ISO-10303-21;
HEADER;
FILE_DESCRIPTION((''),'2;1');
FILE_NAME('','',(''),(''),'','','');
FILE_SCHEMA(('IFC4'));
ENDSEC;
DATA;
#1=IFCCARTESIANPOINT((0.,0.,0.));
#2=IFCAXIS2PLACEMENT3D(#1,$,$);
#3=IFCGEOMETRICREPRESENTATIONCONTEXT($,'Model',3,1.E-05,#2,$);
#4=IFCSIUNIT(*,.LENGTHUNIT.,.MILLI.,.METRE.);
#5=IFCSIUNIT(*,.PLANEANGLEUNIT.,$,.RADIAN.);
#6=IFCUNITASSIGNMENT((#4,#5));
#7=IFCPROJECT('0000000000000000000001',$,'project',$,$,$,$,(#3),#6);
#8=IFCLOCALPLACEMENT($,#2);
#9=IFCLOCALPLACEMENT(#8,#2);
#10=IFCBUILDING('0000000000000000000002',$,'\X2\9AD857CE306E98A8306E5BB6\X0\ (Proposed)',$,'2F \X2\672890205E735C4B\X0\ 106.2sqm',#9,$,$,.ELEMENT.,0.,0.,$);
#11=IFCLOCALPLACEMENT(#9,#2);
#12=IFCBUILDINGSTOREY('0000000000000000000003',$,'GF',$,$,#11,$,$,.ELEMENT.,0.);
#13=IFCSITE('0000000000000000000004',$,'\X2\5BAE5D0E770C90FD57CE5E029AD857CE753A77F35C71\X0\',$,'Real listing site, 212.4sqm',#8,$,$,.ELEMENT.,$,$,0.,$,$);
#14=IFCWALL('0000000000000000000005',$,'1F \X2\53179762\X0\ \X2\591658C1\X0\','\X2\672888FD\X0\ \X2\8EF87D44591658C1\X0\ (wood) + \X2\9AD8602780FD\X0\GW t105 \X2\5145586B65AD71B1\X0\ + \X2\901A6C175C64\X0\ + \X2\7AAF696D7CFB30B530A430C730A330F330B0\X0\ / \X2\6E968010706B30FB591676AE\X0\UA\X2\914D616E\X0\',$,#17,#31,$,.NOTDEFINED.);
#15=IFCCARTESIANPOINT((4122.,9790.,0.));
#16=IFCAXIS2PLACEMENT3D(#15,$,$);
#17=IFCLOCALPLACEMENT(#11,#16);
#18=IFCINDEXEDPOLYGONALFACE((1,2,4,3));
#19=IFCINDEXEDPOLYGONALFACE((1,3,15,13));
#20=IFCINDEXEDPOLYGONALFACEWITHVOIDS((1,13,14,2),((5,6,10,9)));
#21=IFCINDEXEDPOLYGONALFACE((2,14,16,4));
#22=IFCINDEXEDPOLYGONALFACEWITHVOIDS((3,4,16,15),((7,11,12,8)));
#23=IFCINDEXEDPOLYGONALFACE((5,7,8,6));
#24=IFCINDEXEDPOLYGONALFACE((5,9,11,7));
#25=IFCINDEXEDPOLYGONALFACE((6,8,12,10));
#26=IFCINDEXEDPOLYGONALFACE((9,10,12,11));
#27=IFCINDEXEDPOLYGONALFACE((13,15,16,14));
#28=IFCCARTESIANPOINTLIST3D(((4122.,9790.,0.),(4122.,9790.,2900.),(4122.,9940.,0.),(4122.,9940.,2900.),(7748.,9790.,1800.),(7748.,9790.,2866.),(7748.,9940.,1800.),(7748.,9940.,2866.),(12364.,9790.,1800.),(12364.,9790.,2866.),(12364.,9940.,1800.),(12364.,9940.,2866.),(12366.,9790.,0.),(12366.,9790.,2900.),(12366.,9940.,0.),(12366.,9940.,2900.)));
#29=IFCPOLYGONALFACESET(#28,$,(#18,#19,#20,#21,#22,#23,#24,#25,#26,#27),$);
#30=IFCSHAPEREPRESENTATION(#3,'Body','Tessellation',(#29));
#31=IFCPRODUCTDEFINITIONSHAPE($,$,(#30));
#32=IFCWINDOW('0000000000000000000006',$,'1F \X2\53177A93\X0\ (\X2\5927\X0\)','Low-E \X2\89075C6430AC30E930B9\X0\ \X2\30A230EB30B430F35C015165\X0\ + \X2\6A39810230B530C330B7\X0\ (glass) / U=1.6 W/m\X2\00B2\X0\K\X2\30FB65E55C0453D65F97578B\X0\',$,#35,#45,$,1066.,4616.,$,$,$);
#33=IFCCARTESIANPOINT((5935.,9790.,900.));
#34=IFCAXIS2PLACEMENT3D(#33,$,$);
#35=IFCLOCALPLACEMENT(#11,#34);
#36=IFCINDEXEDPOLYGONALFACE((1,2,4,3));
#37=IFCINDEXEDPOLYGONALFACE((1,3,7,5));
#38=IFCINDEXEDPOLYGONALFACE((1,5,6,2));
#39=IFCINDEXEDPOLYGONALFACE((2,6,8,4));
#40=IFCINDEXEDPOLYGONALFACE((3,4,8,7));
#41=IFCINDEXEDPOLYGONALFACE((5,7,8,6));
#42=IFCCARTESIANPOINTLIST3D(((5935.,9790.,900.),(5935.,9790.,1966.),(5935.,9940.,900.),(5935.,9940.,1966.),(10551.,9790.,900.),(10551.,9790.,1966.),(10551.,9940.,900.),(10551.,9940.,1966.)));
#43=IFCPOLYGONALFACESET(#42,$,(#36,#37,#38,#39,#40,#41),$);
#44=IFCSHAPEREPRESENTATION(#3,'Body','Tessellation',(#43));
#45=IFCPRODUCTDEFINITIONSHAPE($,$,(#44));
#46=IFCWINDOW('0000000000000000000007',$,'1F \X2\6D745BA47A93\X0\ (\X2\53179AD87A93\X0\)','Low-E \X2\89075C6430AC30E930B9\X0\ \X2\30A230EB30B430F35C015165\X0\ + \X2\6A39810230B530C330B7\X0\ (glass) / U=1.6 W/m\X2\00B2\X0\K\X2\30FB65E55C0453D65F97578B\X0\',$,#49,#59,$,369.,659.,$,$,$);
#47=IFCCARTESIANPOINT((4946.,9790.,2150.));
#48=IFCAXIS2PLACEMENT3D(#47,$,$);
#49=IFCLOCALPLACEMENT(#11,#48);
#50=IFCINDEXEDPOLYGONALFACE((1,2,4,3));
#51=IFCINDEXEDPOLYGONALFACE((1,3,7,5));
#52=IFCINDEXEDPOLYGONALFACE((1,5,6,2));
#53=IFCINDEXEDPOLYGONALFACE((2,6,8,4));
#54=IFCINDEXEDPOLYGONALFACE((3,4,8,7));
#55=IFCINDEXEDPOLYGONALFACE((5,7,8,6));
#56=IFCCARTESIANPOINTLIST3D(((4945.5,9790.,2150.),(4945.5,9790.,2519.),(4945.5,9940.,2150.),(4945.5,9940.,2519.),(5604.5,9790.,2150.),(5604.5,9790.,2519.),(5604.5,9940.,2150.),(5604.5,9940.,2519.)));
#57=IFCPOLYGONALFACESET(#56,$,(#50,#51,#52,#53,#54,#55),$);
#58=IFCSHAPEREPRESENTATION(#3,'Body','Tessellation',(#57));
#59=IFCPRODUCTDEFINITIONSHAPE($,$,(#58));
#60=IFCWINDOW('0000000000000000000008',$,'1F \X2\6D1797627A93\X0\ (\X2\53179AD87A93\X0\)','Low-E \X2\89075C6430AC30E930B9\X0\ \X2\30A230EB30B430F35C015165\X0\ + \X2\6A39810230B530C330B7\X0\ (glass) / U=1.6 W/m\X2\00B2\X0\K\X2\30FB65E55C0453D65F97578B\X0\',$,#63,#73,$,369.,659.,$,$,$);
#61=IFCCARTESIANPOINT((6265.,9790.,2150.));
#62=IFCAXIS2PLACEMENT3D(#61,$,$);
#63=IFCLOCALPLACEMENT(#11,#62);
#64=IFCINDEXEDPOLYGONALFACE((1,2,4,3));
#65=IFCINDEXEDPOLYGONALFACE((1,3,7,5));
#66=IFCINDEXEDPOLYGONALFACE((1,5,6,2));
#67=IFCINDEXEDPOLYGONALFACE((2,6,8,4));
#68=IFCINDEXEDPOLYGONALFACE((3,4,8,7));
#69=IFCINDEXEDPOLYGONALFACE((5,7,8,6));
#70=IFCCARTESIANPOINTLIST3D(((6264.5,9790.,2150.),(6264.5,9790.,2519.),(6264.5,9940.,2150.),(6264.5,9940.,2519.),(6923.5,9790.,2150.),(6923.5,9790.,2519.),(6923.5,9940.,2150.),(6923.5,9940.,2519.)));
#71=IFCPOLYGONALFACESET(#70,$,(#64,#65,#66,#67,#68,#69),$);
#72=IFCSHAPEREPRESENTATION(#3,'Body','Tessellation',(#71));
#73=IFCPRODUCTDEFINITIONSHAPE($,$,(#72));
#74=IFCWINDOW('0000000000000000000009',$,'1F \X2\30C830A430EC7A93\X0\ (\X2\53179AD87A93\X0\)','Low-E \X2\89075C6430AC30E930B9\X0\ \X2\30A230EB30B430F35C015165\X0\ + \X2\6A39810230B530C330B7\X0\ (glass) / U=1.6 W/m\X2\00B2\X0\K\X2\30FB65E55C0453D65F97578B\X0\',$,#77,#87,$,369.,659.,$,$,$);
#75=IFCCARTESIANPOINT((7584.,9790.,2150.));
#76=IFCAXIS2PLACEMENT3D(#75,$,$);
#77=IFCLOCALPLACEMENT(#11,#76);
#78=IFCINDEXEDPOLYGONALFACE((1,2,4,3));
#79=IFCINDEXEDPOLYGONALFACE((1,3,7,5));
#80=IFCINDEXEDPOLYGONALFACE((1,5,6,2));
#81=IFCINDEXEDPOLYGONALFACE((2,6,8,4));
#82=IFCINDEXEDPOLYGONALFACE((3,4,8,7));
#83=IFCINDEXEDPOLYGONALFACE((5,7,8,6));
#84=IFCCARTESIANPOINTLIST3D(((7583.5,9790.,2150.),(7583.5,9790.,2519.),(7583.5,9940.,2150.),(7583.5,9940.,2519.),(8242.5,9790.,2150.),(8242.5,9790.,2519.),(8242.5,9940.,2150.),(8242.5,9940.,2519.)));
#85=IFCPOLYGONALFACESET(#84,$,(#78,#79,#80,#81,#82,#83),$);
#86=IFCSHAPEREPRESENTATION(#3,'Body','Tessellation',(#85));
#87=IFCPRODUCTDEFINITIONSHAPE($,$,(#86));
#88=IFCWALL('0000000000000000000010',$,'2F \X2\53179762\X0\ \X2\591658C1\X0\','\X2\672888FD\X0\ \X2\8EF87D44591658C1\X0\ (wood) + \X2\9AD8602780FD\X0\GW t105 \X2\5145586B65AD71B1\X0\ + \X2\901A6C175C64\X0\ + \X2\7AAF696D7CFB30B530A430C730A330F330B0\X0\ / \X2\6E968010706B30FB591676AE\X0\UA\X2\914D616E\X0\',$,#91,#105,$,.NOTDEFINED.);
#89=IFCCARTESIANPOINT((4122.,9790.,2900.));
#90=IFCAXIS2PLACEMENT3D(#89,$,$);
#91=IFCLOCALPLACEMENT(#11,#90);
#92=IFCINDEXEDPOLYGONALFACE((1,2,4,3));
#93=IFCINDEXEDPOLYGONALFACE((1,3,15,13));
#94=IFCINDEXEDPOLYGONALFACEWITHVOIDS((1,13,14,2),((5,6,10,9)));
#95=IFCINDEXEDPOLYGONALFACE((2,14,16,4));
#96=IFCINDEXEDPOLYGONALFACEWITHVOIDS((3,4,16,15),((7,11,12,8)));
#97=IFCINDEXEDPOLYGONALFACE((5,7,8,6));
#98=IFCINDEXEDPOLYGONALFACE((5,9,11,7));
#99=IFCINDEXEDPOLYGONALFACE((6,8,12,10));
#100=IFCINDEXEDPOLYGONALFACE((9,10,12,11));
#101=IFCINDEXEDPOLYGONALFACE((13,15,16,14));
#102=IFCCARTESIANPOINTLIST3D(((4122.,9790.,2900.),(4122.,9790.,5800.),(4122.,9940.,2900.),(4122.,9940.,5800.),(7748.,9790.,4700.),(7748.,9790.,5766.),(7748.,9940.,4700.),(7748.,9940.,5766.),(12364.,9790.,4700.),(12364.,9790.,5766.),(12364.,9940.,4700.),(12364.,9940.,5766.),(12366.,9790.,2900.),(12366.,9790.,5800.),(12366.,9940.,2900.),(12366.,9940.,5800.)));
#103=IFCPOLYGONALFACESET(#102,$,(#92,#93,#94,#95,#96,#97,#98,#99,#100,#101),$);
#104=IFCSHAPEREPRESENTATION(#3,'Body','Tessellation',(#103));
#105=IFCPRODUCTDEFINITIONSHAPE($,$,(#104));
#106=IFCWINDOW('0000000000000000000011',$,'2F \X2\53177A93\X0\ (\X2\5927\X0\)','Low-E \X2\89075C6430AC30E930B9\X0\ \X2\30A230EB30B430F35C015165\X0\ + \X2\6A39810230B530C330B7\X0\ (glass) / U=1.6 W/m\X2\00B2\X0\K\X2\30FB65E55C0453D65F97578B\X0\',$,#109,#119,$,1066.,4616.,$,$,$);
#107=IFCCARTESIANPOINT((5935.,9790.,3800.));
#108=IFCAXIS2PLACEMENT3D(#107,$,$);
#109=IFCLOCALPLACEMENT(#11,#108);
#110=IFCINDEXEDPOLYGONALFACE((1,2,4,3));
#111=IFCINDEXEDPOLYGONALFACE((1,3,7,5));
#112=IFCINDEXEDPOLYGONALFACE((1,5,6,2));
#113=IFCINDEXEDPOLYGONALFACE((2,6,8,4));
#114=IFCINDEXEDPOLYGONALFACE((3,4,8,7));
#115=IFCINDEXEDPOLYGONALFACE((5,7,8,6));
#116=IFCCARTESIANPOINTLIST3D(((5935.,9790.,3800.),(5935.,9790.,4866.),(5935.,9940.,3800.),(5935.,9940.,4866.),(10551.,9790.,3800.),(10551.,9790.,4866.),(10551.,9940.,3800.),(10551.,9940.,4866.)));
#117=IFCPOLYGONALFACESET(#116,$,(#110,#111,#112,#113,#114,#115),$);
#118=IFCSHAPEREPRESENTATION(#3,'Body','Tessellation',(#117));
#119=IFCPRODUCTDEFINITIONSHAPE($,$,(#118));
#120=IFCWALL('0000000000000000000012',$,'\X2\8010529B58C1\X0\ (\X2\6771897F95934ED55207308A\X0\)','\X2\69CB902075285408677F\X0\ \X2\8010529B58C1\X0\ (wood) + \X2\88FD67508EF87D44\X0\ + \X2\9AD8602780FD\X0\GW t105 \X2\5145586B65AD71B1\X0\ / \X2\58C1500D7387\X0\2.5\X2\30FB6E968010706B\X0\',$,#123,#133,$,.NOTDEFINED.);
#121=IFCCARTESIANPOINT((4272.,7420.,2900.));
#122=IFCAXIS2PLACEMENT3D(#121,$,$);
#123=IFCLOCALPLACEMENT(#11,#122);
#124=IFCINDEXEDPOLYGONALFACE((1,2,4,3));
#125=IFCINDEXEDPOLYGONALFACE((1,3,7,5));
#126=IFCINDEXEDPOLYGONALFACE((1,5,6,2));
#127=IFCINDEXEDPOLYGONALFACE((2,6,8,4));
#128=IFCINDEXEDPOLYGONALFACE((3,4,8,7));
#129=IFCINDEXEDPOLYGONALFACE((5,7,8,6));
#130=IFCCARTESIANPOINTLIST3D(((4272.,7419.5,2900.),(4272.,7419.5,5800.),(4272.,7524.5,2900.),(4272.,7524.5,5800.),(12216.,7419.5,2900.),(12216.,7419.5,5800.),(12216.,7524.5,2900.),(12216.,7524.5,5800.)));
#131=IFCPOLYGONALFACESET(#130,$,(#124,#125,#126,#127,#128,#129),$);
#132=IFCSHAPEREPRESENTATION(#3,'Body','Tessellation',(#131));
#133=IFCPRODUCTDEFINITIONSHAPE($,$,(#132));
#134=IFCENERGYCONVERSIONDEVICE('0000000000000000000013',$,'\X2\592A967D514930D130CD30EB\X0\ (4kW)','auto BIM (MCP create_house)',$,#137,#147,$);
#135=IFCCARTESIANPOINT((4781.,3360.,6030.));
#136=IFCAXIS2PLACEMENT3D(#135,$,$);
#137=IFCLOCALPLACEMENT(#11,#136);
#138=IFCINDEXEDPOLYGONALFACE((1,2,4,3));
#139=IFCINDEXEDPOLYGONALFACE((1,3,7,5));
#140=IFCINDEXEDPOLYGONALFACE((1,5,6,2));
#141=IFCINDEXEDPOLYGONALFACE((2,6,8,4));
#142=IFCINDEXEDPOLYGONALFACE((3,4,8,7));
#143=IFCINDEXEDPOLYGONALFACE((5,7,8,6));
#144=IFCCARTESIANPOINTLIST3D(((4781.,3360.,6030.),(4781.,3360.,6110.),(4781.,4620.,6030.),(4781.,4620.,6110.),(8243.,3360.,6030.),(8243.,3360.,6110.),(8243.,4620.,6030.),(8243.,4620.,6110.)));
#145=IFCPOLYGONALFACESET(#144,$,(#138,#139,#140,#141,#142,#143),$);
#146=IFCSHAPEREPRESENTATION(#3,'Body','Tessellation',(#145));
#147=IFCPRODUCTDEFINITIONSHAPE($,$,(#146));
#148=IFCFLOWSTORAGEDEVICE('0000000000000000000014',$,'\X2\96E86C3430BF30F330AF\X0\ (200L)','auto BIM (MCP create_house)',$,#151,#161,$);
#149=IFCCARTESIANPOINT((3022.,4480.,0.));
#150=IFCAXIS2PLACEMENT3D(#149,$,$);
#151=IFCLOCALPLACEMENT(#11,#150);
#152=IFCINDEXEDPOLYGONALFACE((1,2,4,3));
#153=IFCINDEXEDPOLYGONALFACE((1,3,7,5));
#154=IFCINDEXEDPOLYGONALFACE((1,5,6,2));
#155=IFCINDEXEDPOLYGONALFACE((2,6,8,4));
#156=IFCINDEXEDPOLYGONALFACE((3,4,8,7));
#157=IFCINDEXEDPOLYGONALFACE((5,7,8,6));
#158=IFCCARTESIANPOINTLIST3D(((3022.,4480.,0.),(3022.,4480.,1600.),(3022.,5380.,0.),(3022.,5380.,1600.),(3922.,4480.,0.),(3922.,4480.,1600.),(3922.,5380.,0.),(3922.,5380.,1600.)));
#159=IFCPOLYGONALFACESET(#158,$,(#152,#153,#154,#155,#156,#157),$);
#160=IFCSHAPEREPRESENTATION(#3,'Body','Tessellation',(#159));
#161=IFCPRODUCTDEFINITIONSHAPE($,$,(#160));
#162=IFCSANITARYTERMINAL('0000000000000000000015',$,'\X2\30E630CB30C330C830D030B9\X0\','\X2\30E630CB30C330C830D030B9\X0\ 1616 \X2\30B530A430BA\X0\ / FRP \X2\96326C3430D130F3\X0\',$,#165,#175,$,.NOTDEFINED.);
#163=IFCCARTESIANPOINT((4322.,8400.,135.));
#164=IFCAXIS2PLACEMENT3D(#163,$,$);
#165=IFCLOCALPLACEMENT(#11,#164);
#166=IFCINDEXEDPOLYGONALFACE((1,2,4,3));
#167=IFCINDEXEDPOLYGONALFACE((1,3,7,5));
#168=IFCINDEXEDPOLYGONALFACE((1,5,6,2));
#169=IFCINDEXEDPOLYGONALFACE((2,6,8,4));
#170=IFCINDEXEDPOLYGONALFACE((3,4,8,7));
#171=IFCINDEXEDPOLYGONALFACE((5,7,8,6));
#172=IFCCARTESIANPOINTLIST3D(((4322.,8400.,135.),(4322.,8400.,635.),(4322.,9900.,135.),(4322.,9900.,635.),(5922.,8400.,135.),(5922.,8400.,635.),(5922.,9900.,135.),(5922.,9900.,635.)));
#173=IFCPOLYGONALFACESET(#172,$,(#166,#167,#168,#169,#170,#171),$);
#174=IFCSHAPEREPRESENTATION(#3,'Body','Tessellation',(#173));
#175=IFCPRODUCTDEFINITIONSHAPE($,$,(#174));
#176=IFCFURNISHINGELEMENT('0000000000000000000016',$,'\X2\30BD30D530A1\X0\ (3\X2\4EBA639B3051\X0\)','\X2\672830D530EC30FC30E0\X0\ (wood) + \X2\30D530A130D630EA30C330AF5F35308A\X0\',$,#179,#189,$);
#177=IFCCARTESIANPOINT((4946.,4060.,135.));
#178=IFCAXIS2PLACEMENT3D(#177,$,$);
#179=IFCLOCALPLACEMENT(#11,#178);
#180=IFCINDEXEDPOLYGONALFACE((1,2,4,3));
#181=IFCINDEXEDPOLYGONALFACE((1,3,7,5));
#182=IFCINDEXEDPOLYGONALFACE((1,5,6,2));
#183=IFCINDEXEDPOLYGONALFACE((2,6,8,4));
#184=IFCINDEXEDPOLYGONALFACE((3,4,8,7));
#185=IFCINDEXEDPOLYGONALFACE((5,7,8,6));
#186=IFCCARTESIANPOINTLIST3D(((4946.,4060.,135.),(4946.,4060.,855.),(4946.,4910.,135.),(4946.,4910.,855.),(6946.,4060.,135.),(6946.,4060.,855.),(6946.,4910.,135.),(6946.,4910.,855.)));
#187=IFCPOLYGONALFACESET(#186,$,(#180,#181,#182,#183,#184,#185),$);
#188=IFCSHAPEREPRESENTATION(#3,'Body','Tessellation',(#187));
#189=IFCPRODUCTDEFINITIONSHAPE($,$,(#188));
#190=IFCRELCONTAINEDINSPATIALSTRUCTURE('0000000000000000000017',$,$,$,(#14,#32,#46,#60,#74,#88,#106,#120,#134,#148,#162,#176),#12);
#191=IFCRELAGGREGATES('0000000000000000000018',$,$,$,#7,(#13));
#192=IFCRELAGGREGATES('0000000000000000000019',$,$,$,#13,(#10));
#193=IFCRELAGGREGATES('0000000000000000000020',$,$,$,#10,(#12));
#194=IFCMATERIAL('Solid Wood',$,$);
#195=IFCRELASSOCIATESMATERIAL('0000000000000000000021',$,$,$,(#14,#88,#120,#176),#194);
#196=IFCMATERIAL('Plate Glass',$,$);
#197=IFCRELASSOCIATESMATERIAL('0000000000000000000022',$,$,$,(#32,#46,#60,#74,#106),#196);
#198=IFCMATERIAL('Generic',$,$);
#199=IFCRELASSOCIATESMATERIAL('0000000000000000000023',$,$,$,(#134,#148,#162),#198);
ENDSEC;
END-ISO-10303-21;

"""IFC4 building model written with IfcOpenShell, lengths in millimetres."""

from ifc_helpers import new_model, si_unit, frame, frame_2d, origin, place, context, project, spatial, rectangle, extrude, material, element, fill, save


model = new_model("IFC4")

# Units and contexts
model_context = context("Model", 3, precision=1e-05, world=origin())
ifc_project = project(units=[si_unit("LENGTHUNIT", "METRE", prefix="MILLI"), si_unit("PLANEANGLEUNIT", "RADIAN")], contexts=[model_context])

# Site, building, storey
site_placement = place(None, origin())
site = spatial("IfcSite", under=ifc_project, at=site_placement, Name="宮崎県都城市高城町石山", ObjectType="Real listing site, 212.4sqm", CompositionType="ELEMENT", RefElevation=0.0)
building_placement = place(site_placement, origin())
building = spatial("IfcBuilding", under=site, at=building_placement, Name="高城の風の家 (Proposed)", ObjectType="2F 木造平屋 106.2sqm", CompositionType="ELEMENT", ElevationOfRefHeight=0.0, ElevationOfTerrain=0.0)
storey_placement = place(building_placement, origin())
storey = spatial("IfcBuildingStorey", under=building, at=storey_placement, Name="GF", CompositionType="ELEMENT", Elevation=0.0)

# Wall, openings, windows
ifc_material_1 = material(Name="Solid Wood")
wall_1_placement = place(storey_placement, frame((4122.0, 9790.0, 0.0)))
wall_1 = element("IfcWall", 1, at=wall_1_placement, inside=storey, material=ifc_material_1, Name="1F 北面 外壁", Description="木製 軸組外壁 (wood) + 高性能GW t105 充填断熱 + 通気層 + 窯業系サイディング / 準耐火・外皮UA配慮", PredefinedType="NOTDEFINED", context=model_context, shape_type="SweptSolid", body=[
    extrude(rectangle(XDim=8244.0, YDim=150.0, at=frame_2d((4122.0, 75.0))), frame((4122.0, 9790.0, 0.0)), (0.0, 0.0, 1.0), 2900.0),
])
opening_1_placement = place(storey_placement, frame((5935.0, 9790.0, 900.0)))
opening_1 = element("IfcOpeningElement", 2, at=opening_1_placement, cuts=wall_1, PredefinedType="NOTDEFINED", context=model_context, shape_type="SweptSolid", body=[
    extrude(rectangle(XDim=4616.0, YDim=150.0, at=frame_2d((2308.0, 75.0))), frame((5935.0, 9790.0, 900.0)), (0.0, 0.0, 1.0), 1066.0),
])
opening_2_placement = place(storey_placement, frame((4946.0, 9790.0, 2150.0)))
opening_2 = element("IfcOpeningElement", 3, at=opening_2_placement, cuts=wall_1, PredefinedType="NOTDEFINED", context=model_context, shape_type="SweptSolid", body=[
    extrude(rectangle(XDim=659.0, YDim=150.0, at=frame_2d((329.0, 75.0))), frame((4946.0, 9790.0, 2150.0)), (0.0, 0.0, 1.0), 369.0),
])
opening_3_placement = place(storey_placement, frame((6265.0, 9790.0, 2150.0)))
opening_3 = element("IfcOpeningElement", 4, at=opening_3_placement, cuts=wall_1, PredefinedType="NOTDEFINED", context=model_context, shape_type="SweptSolid", body=[
    extrude(rectangle(XDim=659.0, YDim=150.0, at=frame_2d((329.0, 75.0))), frame((6265.0, 9790.0, 2150.0)), (0.0, 0.0, 1.0), 369.0),
])
opening_4_placement = place(storey_placement, frame((7584.0, 9790.0, 2150.0)))
opening_4 = element("IfcOpeningElement", 5, at=opening_4_placement, cuts=wall_1, PredefinedType="NOTDEFINED", context=model_context, shape_type="SweptSolid", body=[
    extrude(rectangle(XDim=659.0, YDim=150.0, at=frame_2d((329.0, 75.0))), frame((7584.0, 9790.0, 2150.0)), (0.0, 0.0, 1.0), 369.0),
])
ifc_material_2 = material(Name="Plate Glass")
window_1_placement = place(storey_placement, frame((5935.0, 9790.0, 900.0)))
window_1 = element("IfcWindow", 6, at=window_1_placement, inside=storey, material=ifc_material_2, Name="1F 北窓 (大)", Description="Low-E 複層ガラス アルゴン封入 + 樹脂サッシ (glass) / U=1.6 W/m²K・日射取得型", OverallHeight=1066.0, OverallWidth=4616.0, context=model_context, shape_type="SweptSolid", body=[
    extrude(rectangle(XDim=4616.0, YDim=150.0, at=frame_2d((2308.0, 75.0))), frame((5935.0, 9790.0, 900.0)), (0.0, 0.0, 1.0), 1066.0),
])
fill(opening_1, window_1)
window_2_placement = place(storey_placement, frame((4946.0, 9790.0, 2150.0)))
window_2 = element("IfcWindow", 7, at=window_2_placement, inside=storey, material=ifc_material_2, Name="1F 浴室窓 (北高窓)", Description="Low-E 複層ガラス アルゴン封入 + 樹脂サッシ (glass) / U=1.6 W/m²K・日射取得型", OverallHeight=369.0, OverallWidth=659.0, context=model_context, shape_type="SweptSolid", body=[
    extrude(rectangle(XDim=659.0, YDim=150.0, at=frame_2d((329.0, 75.0))), frame((4946.0, 9790.0, 2150.0)), (0.0, 0.0, 1.0), 369.0),
])
fill(opening_2, window_2)
window_3_placement = place(storey_placement, frame((6265.0, 9790.0, 2150.0)))
window_3 = element("IfcWindow", 8, at=window_3_placement, inside=storey, material=ifc_material_2, Name="1F 洗面窓 (北高窓)", Description="Low-E 複層ガラス アルゴン封入 + 樹脂サッシ (glass) / U=1.6 W/m²K・日射取得型", OverallHeight=369.0, OverallWidth=659.0, context=model_context, shape_type="SweptSolid", body=[
    extrude(rectangle(XDim=659.0, YDim=150.0, at=frame_2d((329.0, 75.0))), frame((6265.0, 9790.0, 2150.0)), (0.0, 0.0, 1.0), 369.0),
])
fill(opening_3, window_3)
window_4_placement = place(storey_placement, frame((7584.0, 9790.0, 2150.0)))
window_4 = element("IfcWindow", 9, at=window_4_placement, inside=storey, material=ifc_material_2, Name="1F トイレ窓 (北高窓)", Description="Low-E 複層ガラス アルゴン封入 + 樹脂サッシ (glass) / U=1.6 W/m²K・日射取得型", OverallHeight=369.0, OverallWidth=659.0, context=model_context, shape_type="SweptSolid", body=[
    extrude(rectangle(XDim=659.0, YDim=150.0, at=frame_2d((329.0, 75.0))), frame((7584.0, 9790.0, 2150.0)), (0.0, 0.0, 1.0), 369.0),
])
fill(opening_4, window_4)

# Wall, opening, window
wall_2_placement = place(storey_placement, frame((4122.0, 9790.0, 2900.0)))
wall_2 = element("IfcWall", 10, at=wall_2_placement, inside=storey, material=ifc_material_1, Name="2F 北面 外壁", Description="木製 軸組外壁 (wood) + 高性能GW t105 充填断熱 + 通気層 + 窯業系サイディング / 準耐火・外皮UA配慮", PredefinedType="NOTDEFINED", context=model_context, shape_type="SweptSolid", body=[
    extrude(rectangle(XDim=8244.0, YDim=150.0, at=frame_2d((4122.0, 75.0))), frame((4122.0, 9790.0, 2900.0)), (0.0, 0.0, 1.0), 2900.0),
])
opening_5_placement = place(storey_placement, frame((5935.0, 9790.0, 3800.0)))
opening_5 = element("IfcOpeningElement", 11, at=opening_5_placement, cuts=wall_2, PredefinedType="NOTDEFINED", context=model_context, shape_type="SweptSolid", body=[
    extrude(rectangle(XDim=4616.0, YDim=150.0, at=frame_2d((2308.0, 75.0))), frame((5935.0, 9790.0, 3800.0)), (0.0, 0.0, 1.0), 1066.0),
])
window_5_placement = place(storey_placement, frame((5935.0, 9790.0, 3800.0)))
window_5 = element("IfcWindow", 12, at=window_5_placement, inside=storey, material=ifc_material_2, Name="2F 北窓 (大)", Description="Low-E 複層ガラス アルゴン封入 + 樹脂サッシ (glass) / U=1.6 W/m²K・日射取得型", OverallHeight=1066.0, OverallWidth=4616.0, context=model_context, shape_type="SweptSolid", body=[
    extrude(rectangle(XDim=4616.0, YDim=150.0, at=frame_2d((2308.0, 75.0))), frame((5935.0, 9790.0, 3800.0)), (0.0, 0.0, 1.0), 1066.0),
])
fill(opening_5, window_5)

# Wall
wall_3_placement = place(storey_placement, frame((4272.0, 7420.0, 2900.0)))
element("IfcWall", 13, at=wall_3_placement, inside=storey, material=ifc_material_1, Name="耐力壁 (東西間仕切り)", Description="構造用合板 耐力壁 (wood) + 製材軸組 + 高性能GW t105 充填断熱 / 壁倍率2.5・準耐火", PredefinedType="NOTDEFINED", context=model_context, shape_type="SweptSolid", body=[
    extrude(rectangle(XDim=7944.0, YDim=105.0, at=frame_2d((3972.0, 52.0))), frame((4272.0, 7420.0, 2900.0)), (0.0, 0.0, 1.0), 2900.0),
])

# Energy conversion device
ifc_material_3 = material(Name="Generic")
energy_conversion_device_placement = place(storey_placement, frame((4781.0, 3360.0, 6030.0)))
element("IfcEnergyConversionDevice", 14, at=energy_conversion_device_placement, inside=storey, material=ifc_material_3, Name="太陽光パネル (4kW)", Description="auto BIM (MCP create_house)", context=model_context, shape_type="SweptSolid", body=[
    extrude(rectangle(XDim=3462.0, YDim=1260.0, at=frame_2d((1731.0, 630.0))), frame((4781.0, 3360.0, 6030.0)), (0.0, 0.0, 1.0), 80.0),
])

# Flow storage device
flow_storage_device_placement = place(storey_placement, frame((3022.0, 4480.0, 0.0)))
element("IfcFlowStorageDevice", 15, at=flow_storage_device_placement, inside=storey, material=ifc_material_3, Name="雨水タンク (200L)", Description="auto BIM (MCP create_house)", context=model_context, shape_type="SweptSolid", body=[
    extrude(rectangle(XDim=900.0, YDim=900.0, at=frame_2d((450.0, 450.0))), frame((3022.0, 4480.0, 0.0)), (0.0, 0.0, 1.0), 1600.0),
])

# Sanitary terminal
sanitary_terminal_placement = place(storey_placement, frame((4322.0, 8400.0, 135.0)))
element("IfcSanitaryTerminal", 16, at=sanitary_terminal_placement, inside=storey, material=ifc_material_3, Name="ユニットバス", Description="ユニットバス 1616 サイズ / FRP 防水パン", PredefinedType="NOTDEFINED", context=model_context, shape_type="SweptSolid", body=[
    extrude(rectangle(XDim=1600.0, YDim=1500.0, at=frame_2d((800.0, 750.0))), frame((4322.0, 8400.0, 135.0)), (0.0, 0.0, 1.0), 500.0),
])

# Furnishing element
furnishing_1_placement = place(storey_placement, frame((4946.0, 4060.0, 135.0)))
element("IfcFurnishingElement", 17, at=furnishing_1_placement, inside=storey, material=ifc_material_1, Name="ソファ (3人掛け)", Description="木フレーム (wood) + ファブリック張り", context=model_context, shape_type="SweptSolid", body=[
    extrude(rectangle(XDim=2000.0, YDim=850.0, at=frame_2d((1000.0, 425.0))), frame((4946.0, 4060.0, 135.0)), (0.0, 0.0, 1.0), 720.0),
])

save(model, "model.ifc")
